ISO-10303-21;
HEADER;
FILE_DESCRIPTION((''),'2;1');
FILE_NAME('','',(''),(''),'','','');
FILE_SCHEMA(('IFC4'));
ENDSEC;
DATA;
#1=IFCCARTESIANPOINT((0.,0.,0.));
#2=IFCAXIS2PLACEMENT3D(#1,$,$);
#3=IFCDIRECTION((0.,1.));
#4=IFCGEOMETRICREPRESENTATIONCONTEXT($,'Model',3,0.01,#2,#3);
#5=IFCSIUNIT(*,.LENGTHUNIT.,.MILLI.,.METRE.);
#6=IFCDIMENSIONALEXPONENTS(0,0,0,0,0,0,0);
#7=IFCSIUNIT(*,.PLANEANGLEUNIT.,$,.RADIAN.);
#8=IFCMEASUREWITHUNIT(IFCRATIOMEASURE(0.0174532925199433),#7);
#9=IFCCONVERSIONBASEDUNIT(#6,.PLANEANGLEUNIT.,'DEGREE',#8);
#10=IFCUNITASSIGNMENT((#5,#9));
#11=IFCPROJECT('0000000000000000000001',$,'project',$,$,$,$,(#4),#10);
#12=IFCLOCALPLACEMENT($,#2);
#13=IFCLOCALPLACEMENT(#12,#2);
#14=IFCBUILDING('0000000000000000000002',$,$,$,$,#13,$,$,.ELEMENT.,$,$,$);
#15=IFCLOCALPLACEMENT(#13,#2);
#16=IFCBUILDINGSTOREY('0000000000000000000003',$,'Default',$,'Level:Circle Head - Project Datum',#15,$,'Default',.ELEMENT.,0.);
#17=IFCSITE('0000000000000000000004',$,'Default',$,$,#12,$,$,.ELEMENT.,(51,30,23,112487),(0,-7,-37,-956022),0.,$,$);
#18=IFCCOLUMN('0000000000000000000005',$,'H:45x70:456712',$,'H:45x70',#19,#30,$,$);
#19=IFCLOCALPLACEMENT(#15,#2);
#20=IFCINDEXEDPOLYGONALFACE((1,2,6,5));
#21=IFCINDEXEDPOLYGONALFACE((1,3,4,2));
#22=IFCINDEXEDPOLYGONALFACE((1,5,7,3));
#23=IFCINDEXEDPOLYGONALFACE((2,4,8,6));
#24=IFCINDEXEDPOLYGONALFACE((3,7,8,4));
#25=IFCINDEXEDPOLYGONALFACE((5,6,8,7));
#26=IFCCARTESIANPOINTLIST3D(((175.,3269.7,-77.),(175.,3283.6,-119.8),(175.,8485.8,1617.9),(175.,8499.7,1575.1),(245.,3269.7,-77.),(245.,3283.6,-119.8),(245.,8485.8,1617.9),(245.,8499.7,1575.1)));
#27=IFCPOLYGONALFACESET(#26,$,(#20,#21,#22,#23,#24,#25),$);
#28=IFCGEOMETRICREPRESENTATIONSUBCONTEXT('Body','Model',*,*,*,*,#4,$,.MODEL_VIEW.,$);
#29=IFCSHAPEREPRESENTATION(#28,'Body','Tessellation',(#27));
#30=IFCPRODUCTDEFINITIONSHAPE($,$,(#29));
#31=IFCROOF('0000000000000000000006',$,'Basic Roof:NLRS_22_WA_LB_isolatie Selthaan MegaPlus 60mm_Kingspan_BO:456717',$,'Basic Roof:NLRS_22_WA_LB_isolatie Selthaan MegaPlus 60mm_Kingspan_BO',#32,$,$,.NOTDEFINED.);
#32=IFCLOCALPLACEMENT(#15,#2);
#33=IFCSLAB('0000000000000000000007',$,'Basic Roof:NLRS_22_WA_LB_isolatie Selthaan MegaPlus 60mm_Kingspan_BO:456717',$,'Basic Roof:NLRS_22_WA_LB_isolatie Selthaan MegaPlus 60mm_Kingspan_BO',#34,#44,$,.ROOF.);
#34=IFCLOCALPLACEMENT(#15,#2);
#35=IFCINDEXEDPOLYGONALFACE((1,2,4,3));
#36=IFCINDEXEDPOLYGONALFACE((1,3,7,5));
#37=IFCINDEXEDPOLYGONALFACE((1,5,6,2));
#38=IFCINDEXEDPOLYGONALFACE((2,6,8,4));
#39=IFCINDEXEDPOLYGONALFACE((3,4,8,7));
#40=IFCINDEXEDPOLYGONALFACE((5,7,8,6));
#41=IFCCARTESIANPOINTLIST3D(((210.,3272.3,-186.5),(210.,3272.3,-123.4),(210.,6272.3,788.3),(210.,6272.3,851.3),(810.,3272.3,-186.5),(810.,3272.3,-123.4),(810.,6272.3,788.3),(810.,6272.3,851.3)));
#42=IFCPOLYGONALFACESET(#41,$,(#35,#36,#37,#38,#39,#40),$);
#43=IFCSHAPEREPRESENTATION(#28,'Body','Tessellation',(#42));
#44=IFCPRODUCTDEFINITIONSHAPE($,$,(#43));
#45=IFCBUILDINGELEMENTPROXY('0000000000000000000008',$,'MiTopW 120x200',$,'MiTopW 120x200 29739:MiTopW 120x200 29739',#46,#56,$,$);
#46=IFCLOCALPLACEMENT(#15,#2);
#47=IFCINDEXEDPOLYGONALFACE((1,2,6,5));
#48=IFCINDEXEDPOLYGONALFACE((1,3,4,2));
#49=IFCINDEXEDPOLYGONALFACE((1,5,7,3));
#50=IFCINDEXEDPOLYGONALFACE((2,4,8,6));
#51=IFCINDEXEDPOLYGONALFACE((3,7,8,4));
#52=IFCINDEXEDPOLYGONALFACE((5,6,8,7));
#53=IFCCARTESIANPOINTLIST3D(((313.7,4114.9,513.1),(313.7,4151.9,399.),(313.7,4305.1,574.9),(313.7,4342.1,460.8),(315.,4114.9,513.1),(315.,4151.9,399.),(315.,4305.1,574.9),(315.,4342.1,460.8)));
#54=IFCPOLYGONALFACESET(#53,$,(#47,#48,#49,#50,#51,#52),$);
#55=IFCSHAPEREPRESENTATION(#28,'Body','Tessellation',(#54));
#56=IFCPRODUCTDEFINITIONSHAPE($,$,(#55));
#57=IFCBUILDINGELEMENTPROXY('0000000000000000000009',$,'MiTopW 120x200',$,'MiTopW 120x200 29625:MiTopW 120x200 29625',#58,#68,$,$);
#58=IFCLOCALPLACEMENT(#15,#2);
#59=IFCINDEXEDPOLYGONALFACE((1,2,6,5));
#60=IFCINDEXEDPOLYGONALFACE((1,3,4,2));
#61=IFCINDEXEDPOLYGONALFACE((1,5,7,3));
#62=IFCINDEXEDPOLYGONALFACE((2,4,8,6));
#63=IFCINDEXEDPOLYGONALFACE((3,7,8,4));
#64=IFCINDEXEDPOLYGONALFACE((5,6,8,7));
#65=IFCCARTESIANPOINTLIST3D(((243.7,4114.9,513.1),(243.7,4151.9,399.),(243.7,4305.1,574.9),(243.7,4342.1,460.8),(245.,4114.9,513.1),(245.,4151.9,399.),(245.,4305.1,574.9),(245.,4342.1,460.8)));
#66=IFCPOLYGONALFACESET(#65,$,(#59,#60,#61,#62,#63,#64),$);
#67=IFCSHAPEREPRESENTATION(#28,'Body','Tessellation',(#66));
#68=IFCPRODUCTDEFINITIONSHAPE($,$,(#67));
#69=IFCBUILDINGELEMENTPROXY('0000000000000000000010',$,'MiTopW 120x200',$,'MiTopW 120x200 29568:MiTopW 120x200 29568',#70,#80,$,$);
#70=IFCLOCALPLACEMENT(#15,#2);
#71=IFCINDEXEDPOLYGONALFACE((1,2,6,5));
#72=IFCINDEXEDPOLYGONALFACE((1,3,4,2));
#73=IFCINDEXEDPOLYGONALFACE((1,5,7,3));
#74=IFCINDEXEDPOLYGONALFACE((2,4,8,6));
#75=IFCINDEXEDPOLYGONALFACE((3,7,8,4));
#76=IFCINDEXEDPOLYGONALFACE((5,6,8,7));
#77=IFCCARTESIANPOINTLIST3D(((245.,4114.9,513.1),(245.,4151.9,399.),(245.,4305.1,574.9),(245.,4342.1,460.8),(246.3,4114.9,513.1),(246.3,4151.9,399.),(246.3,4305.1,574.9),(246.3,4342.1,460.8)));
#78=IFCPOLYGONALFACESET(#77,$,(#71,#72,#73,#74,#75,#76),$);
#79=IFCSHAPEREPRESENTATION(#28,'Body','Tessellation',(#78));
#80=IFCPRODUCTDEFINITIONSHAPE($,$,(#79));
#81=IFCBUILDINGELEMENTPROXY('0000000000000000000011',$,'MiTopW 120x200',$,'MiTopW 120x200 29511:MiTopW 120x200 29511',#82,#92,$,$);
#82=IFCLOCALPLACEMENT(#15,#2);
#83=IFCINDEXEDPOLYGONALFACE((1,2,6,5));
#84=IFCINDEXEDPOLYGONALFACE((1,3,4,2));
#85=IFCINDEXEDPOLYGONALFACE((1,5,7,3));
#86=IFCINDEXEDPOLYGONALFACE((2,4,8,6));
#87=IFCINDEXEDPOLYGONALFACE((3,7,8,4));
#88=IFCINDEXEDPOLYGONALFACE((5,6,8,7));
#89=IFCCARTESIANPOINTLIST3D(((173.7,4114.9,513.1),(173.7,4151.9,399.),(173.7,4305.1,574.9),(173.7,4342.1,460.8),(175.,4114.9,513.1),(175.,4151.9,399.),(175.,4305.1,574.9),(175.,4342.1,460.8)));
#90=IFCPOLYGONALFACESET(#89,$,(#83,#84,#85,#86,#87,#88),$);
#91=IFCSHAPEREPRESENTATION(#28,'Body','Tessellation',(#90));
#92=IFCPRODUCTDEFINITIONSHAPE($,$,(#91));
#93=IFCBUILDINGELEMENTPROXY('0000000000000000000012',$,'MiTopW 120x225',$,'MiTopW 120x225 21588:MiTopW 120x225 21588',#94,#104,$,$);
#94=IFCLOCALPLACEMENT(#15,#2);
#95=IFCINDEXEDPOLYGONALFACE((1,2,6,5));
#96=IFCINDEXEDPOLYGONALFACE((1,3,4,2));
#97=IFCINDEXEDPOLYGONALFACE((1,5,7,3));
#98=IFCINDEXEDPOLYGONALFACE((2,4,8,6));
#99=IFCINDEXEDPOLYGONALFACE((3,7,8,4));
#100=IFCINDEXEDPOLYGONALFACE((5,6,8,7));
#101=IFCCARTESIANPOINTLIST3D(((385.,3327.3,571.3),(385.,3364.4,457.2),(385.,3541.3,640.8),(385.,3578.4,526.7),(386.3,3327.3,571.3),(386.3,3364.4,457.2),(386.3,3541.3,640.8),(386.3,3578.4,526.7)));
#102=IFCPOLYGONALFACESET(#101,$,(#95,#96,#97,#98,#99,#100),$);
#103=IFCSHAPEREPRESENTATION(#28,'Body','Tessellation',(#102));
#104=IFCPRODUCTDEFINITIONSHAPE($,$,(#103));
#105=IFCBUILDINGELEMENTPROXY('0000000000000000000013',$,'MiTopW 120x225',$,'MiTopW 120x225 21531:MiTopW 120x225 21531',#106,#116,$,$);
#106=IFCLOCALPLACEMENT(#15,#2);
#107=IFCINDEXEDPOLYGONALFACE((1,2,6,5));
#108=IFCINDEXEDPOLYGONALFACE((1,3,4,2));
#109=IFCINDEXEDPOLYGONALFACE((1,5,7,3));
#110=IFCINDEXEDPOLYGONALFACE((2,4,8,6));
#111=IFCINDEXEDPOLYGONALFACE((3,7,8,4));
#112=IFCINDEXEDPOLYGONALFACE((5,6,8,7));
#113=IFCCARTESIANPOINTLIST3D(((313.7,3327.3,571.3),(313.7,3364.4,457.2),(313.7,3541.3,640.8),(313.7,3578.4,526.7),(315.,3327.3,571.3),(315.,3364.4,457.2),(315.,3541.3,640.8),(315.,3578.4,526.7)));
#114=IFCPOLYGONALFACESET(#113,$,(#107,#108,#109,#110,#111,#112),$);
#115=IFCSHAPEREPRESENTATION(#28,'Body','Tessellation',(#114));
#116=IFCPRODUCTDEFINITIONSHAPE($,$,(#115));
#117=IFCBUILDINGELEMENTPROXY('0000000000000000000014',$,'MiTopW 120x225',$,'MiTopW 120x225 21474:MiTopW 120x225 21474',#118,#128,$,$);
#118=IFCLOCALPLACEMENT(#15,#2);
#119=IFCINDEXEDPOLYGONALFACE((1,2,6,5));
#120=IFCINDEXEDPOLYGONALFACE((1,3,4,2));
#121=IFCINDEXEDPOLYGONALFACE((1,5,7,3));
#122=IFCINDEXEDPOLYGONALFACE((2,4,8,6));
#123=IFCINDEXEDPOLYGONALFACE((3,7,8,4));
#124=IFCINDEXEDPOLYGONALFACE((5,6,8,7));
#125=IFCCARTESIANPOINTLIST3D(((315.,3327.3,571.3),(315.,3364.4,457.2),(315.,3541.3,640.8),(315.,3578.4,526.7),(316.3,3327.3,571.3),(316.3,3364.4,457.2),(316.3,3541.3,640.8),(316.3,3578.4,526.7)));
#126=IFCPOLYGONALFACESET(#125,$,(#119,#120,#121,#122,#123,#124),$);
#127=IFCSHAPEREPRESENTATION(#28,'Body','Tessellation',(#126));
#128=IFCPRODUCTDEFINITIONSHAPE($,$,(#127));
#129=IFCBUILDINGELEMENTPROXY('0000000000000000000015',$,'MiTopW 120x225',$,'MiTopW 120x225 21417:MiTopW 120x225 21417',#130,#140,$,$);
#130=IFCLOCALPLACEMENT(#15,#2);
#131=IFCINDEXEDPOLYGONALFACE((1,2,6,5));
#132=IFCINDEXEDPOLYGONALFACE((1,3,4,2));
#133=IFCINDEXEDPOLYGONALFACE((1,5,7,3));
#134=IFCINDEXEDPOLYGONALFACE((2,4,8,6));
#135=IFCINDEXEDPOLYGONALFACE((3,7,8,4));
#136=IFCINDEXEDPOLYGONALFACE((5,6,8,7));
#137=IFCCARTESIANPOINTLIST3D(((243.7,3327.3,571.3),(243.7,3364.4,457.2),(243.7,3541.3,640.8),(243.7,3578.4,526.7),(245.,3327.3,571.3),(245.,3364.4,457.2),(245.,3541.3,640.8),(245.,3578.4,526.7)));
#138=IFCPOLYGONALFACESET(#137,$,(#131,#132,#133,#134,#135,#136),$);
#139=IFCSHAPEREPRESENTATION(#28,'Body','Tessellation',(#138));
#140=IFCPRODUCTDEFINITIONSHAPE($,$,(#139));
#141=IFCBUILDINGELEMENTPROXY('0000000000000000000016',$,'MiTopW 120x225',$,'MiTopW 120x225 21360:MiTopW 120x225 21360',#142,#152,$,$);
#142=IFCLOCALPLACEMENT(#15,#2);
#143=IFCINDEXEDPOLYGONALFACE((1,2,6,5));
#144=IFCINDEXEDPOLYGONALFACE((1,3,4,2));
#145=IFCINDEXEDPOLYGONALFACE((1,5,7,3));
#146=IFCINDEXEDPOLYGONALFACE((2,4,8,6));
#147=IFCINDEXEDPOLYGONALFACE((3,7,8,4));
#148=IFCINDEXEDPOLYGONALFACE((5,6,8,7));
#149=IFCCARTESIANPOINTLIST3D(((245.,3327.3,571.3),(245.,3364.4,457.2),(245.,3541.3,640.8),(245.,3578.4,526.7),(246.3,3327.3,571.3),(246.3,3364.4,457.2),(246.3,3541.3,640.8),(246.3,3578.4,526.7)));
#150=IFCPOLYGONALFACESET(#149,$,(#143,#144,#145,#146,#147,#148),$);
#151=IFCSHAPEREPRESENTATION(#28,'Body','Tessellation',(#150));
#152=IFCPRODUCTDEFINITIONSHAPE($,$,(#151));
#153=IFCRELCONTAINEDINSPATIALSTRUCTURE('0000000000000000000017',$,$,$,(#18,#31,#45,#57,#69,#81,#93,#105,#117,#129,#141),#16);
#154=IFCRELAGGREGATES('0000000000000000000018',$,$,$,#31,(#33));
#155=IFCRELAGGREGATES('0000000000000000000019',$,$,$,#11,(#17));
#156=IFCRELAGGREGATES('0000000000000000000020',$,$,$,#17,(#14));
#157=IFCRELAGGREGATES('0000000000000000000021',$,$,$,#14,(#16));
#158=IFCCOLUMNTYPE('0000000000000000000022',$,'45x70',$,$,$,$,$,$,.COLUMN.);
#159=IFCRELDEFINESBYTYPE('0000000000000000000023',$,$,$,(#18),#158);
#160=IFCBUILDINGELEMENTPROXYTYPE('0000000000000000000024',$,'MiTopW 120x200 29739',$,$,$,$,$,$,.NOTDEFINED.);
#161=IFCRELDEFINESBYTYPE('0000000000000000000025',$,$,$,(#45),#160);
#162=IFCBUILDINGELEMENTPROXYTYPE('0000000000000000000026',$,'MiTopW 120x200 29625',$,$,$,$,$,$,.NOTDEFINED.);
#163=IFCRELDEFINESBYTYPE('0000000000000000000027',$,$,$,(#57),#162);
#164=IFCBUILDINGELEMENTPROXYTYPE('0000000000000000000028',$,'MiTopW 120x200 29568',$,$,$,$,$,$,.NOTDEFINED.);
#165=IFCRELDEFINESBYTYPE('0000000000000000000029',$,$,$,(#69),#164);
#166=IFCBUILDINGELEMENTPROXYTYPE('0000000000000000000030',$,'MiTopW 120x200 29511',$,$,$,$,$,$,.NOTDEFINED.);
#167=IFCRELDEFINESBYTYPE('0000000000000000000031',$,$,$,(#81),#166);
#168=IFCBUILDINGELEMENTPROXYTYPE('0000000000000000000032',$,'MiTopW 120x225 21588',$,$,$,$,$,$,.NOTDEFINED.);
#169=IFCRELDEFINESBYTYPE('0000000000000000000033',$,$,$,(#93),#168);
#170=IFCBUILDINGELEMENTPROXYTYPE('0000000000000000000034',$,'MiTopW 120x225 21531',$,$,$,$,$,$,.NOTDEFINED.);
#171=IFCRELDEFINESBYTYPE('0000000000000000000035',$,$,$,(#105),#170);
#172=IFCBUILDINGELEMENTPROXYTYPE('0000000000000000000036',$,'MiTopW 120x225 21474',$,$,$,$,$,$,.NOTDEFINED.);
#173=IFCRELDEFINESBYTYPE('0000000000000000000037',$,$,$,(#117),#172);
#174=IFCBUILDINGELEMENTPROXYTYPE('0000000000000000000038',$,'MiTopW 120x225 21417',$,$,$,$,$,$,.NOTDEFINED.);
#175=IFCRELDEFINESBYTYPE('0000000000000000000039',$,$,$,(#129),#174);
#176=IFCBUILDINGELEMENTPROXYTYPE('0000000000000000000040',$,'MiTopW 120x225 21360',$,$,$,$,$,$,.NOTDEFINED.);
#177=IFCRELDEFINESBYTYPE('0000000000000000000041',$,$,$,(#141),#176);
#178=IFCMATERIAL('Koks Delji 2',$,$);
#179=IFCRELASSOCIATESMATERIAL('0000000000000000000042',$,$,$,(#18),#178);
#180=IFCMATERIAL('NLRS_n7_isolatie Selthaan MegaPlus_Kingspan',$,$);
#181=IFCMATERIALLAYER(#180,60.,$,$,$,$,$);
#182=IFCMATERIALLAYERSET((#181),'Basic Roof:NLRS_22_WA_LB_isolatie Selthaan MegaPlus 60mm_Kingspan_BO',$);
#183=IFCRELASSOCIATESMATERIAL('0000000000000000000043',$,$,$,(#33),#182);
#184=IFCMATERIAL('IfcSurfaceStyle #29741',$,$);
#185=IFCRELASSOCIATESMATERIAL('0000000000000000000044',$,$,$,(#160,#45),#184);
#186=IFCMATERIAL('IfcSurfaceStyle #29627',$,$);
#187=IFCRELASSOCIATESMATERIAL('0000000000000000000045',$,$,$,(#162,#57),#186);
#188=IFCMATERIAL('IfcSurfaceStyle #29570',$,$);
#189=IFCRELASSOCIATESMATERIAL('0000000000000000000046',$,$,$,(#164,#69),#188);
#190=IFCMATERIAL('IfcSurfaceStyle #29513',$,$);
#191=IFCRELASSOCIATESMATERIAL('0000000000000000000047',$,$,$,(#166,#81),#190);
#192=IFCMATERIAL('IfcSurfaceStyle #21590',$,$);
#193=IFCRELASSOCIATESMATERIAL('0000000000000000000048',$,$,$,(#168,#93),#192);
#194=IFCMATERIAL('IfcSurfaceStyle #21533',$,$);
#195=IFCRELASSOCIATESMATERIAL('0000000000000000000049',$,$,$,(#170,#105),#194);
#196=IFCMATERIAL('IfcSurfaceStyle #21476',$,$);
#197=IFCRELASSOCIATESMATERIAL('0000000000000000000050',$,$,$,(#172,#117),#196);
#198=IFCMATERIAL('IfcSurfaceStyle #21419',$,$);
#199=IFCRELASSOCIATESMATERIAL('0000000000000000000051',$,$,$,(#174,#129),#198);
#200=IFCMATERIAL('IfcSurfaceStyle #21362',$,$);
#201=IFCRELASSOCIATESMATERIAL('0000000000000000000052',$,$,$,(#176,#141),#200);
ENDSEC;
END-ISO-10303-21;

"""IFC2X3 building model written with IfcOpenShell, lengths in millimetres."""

from ifc_helpers import new_model, entity, si_unit, converted_unit, direction, frame, frame_2d, origin, place, context, subcontext, project, spatial, polyline, rectangle, outline, extrude, source, transform, mapped, material, layer, layer_set, type_object, type_shapes, element, aggregate, save


model = new_model("IFC2X3")

# Units and contexts
model_context = context("Model", 3, precision=0.01, world=origin(), true_north=direction((0.0, 1.0)))
body_context = subcontext(model_context, "Body", "Model", "MODEL_VIEW")
ifc_project = project(units=[si_unit("LENGTHUNIT", "METRE", prefix="MILLI"), converted_unit("PLANEANGLEUNIT", "DEGREE", entity("IfcRatioMeasure", 0.0174532925199433), si_unit("PLANEANGLEUNIT", "RADIAN"), dimensions=[0, 0, 0, 0, 0, 0, 0])], contexts=[model_context])

# Site, building, storey
site_placement = place(None, origin())
site = spatial("IfcSite", under=ifc_project, at=site_placement, Name="Default", CompositionType="ELEMENT", RefLatitude=(51, 30, 23, 112487), RefLongitude=(0, -7, -37, -956022), RefElevation=0.0)
building_placement = place(site_placement, origin())
building = spatial("IfcBuilding", under=site, at=building_placement, CompositionType="ELEMENT")
storey_placement = place(building_placement, origin())
storey = spatial("IfcBuildingStorey", under=building, at=storey_placement, Name="Default", ObjectType="Level:Circle Head - Project Datum", LongName="Default", CompositionType="ELEMENT", Elevation=0.0)

# Column
ifc_material_1 = material(Name="Koks Delji 2")
column_type_1 = type_object("IfcColumnType", Name="45x70", PredefinedType="COLUMN")
shared_shape_1 = source(origin(), body_context, "Body", "SweptSolid", [
    extrude(rectangle(XDim=5484.5, YDim=70.0, at=frame_2d((0.0, 0.0), x_axis=(1.0, 0.0))), frame((2608.0, 237.8, 847.4), z_axis=(-0.309017, 0.0, 0.951057), x_axis=(-0.951057, 0.0, -0.309017)), (0.0, 0.0, 1.0), 45.0),
])
type_shapes(column_type_1, [shared_shape_1])
column_1_placement = place(storey_placement, frame((447.8, 3283.6, -119.8), z_axis=(0.0, 0.0, 1.0), x_axis=(0.0, 1.0, 0.0)))
element("IfcColumn", 1, at=column_1_placement, inside=storey, type_object=column_type_1, material=ifc_material_1, Name="H:45x70:456712", ObjectType="H:45x70", context=body_context, shape_type="MappedRepresentation", body=[
    mapped(shared_shape_1, transform((0.0, 0.0, 0.0), scale=1.0)),
])

# Roof, slab
roof_placement = place(storey_placement, frame((210.0, 3272.3, -186.5)))
roof = element("IfcRoof", 2, at=roof_placement, inside=storey, Name="Basic Roof:NLRS_22_WA_LB_isolatie Selthaan MegaPlus 60mm_Kingspan_BO:456717", ObjectType="Basic Roof:NLRS_22_WA_LB_isolatie Selthaan MegaPlus 60mm_Kingspan_BO", ShapeType="NOTDEFINED")
ifc_material_2 = material(Name="NLRS_n7_isolatie Selthaan MegaPlus_Kingspan")
ifc_layer = layer(ifc_material_2, 60.0)
ifc_layer_set = layer_set([ifc_layer], Name="Basic Roof:NLRS_22_WA_LB_isolatie Selthaan MegaPlus 60mm_Kingspan_BO")
slab_placement = place(roof_placement, origin())
slab = element("IfcSlab", 3, at=slab_placement, material=ifc_layer_set, Name="Basic Roof:NLRS_22_WA_LB_isolatie Selthaan MegaPlus 60mm_Kingspan_BO:456717", ObjectType="Basic Roof:NLRS_22_WA_LB_isolatie Selthaan MegaPlus 60mm_Kingspan_BO", PredefinedType="ROOF", context=body_context, shape_type="SweptSolid", body=[
    extrude(rectangle(XDim=600.0, YDim=3154.4, at=frame_2d((0.0, 0.0), x_axis=(-1.0, 0.0))), frame((300.0, 1500.0, 487.4), z_axis=(0.0, -0.309017, 0.951057), x_axis=(1.0, 0.0, 0.0)), (0.0, 0.309017, 0.951057), 63.1),
])
aggregate(roof, [slab])

# Building element proxies
ifc_material_3 = material(Name="IfcSurfaceStyle #29741")
building_element_proxy_type_1 = type_object("IfcBuildingElementProxyType", Name="MiTopW 120x200 29739", PredefinedType="NOTDEFINED", material=ifc_material_3)
shared_shape_2 = source(origin(), body_context, "Body", "SweptSolid", [
    extrude(outline(polyline([(-100.0, -60.0), (100.0, -60.0), (100.0, 60.0), (-100.0, 60.0), (-100.0, -60.0)])), frame((100.0, 60.0, 0.0), z_axis=(0.0, 0.0, 1.0), x_axis=(-1.0, 0.0, 0.0)), (0.0, 0.0, 1.0), 1.3),
])
type_shapes(building_element_proxy_type_1, [shared_shape_2])
proxy_1_placement = place(building_placement, frame((315.0, 4114.9, 513.1), z_axis=(-1.0, 0.0, 0.0), x_axis=(0.0, 0.951057, 0.309017)))
element("IfcBuildingElementProxy", 4, at=proxy_1_placement, inside=storey, type_object=building_element_proxy_type_1, material=ifc_material_3, Name="MiTopW 120x200", ObjectType="MiTopW 120x200 29739:MiTopW 120x200 29739", context=body_context, shape_type="MappedRepresentation", body=[
    mapped(shared_shape_2, transform((0.0, 0.0, 0.0), scale=1.0)),
])
ifc_material_4 = material(Name="IfcSurfaceStyle #29627")
building_element_proxy_type_2 = type_object("IfcBuildingElementProxyType", Name="MiTopW 120x200 29625", PredefinedType="NOTDEFINED", material=ifc_material_4)
shared_shape_3 = source(origin(), body_context, "Body", "SweptSolid", [
    extrude(outline(polyline([(-100.0, -60.0), (100.0, -60.0), (100.0, 60.0), (-100.0, 60.0), (-100.0, -60.0)])), frame((100.0, 60.0, 0.0), z_axis=(0.0, 0.0, 1.0), x_axis=(-1.0, 0.0, 0.0)), (0.0, 0.0, 1.0), 1.3),
])
type_shapes(building_element_proxy_type_2, [shared_shape_3])
proxy_2_placement = place(building_placement, frame((245.0, 4114.9, 513.1), z_axis=(-1.0, 0.0, 0.0), x_axis=(0.0, 0.951057, 0.309017)))
element("IfcBuildingElementProxy", 5, at=proxy_2_placement, inside=storey, type_object=building_element_proxy_type_2, material=ifc_material_4, Name="MiTopW 120x200", ObjectType="MiTopW 120x200 29625:MiTopW 120x200 29625", context=body_context, shape_type="MappedRepresentation", body=[
    mapped(shared_shape_3, transform((0.0, 0.0, 0.0), scale=1.0)),
])
ifc_material_5 = material(Name="IfcSurfaceStyle #29570")
building_element_proxy_type_3 = type_object("IfcBuildingElementProxyType", Name="MiTopW 120x200 29568", PredefinedType="NOTDEFINED", material=ifc_material_5)
shared_shape_4 = source(origin(), body_context, "Body", "SweptSolid", [
    extrude(outline(polyline([(-100.0, -60.0), (100.0, -60.0), (100.0, 60.0), (-100.0, 60.0), (-100.0, -60.0)])), frame((100.0, 60.0, 0.0), z_axis=(0.0, 0.0, 1.0), x_axis=(-1.0, 0.0, 0.0)), (0.0, 0.0, 1.0), 1.3),
])
type_shapes(building_element_proxy_type_3, [shared_shape_4])
proxy_3_placement = place(building_placement, frame((246.3, 4114.9, 513.1), z_axis=(-1.0, 0.0, 0.0), x_axis=(0.0, 0.951057, 0.309017)))
element("IfcBuildingElementProxy", 6, at=proxy_3_placement, inside=storey, type_object=building_element_proxy_type_3, material=ifc_material_5, Name="MiTopW 120x200", ObjectType="MiTopW 120x200 29568:MiTopW 120x200 29568", context=body_context, shape_type="MappedRepresentation", body=[
    mapped(shared_shape_4, transform((0.0, 0.0, 0.0), scale=1.0)),
])
ifc_material_6 = material(Name="IfcSurfaceStyle #29513")
building_element_proxy_type_4 = type_object("IfcBuildingElementProxyType", Name="MiTopW 120x200 29511", PredefinedType="NOTDEFINED", material=ifc_material_6)
shared_shape_5 = source(origin(), body_context, "Body", "SweptSolid", [
    extrude(outline(polyline([(-100.0, -60.0), (100.0, -60.0), (100.0, 60.0), (-100.0, 60.0), (-100.0, -60.0)])), frame((100.0, 60.0, 0.0), z_axis=(0.0, 0.0, 1.0), x_axis=(-1.0, 0.0, 0.0)), (0.0, 0.0, 1.0), 1.3),
])
type_shapes(building_element_proxy_type_4, [shared_shape_5])
proxy_4_placement = place(building_placement, frame((175.0, 4114.9, 513.1), z_axis=(-1.0, 0.0, 0.0), x_axis=(0.0, 0.951057, 0.309017)))
element("IfcBuildingElementProxy", 7, at=proxy_4_placement, inside=storey, type_object=building_element_proxy_type_4, material=ifc_material_6, Name="MiTopW 120x200", ObjectType="MiTopW 120x200 29511:MiTopW 120x200 29511", context=body_context, shape_type="MappedRepresentation", body=[
    mapped(shared_shape_5, transform((0.0, 0.0, 0.0), scale=1.0)),
])
ifc_material_7 = material(Name="IfcSurfaceStyle #21590")
building_element_proxy_type_5 = type_object("IfcBuildingElementProxyType", Name="MiTopW 120x225 21588", PredefinedType="NOTDEFINED", material=ifc_material_7)
shared_shape_6 = source(origin(), body_context, "Body", "SweptSolid", [
    extrude(outline(polyline([(-112.5, -60.0), (112.5, -60.0), (112.5, 60.0), (-112.5, 60.0), (-112.5, -60.0)])), frame((112.5, 60.0, 0.0), z_axis=(0.0, 0.0, 1.0), x_axis=(-1.0, 0.0, 0.0)), (0.0, 0.0, 1.0), 1.3),
])
type_shapes(building_element_proxy_type_5, [shared_shape_6])
proxy_5_placement = place(building_placement, frame((386.3, 3327.3, 571.3), z_axis=(-1.0, 0.0, 0.0), x_axis=(0.0, 0.951057, 0.309017)))
element("IfcBuildingElementProxy", 8, at=proxy_5_placement, inside=storey, type_object=building_element_proxy_type_5, material=ifc_material_7, Name="MiTopW 120x225", ObjectType="MiTopW 120x225 21588:MiTopW 120x225 21588", context=body_context, shape_type="MappedRepresentation", body=[
    mapped(shared_shape_6, transform((0.0, 0.0, 0.0), scale=1.0)),
])
ifc_material_8 = material(Name="IfcSurfaceStyle #21533")
building_element_proxy_type_6 = type_object("IfcBuildingElementProxyType", Name="MiTopW 120x225 21531", PredefinedType="NOTDEFINED", material=ifc_material_8)
shared_shape_7 = source(origin(), body_context, "Body", "SweptSolid", [
    extrude(outline(polyline([(-112.5, -60.0), (112.5, -60.0), (112.5, 60.0), (-112.5, 60.0), (-112.5, -60.0)])), frame((112.5, 60.0, 0.0), z_axis=(0.0, 0.0, 1.0), x_axis=(-1.0, 0.0, 0.0)), (0.0, 0.0, 1.0), 1.3),
])
type_shapes(building_element_proxy_type_6, [shared_shape_7])
proxy_6_placement = place(building_placement, frame((315.0, 3327.3, 571.3), z_axis=(-1.0, 0.0, 0.0), x_axis=(0.0, 0.951057, 0.309017)))
element("IfcBuildingElementProxy", 9, at=proxy_6_placement, inside=storey, type_object=building_element_proxy_type_6, material=ifc_material_8, Name="MiTopW 120x225", ObjectType="MiTopW 120x225 21531:MiTopW 120x225 21531", context=body_context, shape_type="MappedRepresentation", body=[
    mapped(shared_shape_7, transform((0.0, 0.0, 0.0), scale=1.0)),
])
ifc_material_9 = material(Name="IfcSurfaceStyle #21476")
building_element_proxy_type_7 = type_object("IfcBuildingElementProxyType", Name="MiTopW 120x225 21474", PredefinedType="NOTDEFINED", material=ifc_material_9)
shared_shape_8 = source(origin(), body_context, "Body", "SweptSolid", [
    extrude(outline(polyline([(-112.5, -60.0), (112.5, -60.0), (112.5, 60.0), (-112.5, 60.0), (-112.5, -60.0)])), frame((112.5, 60.0, 0.0), z_axis=(0.0, 0.0, 1.0), x_axis=(-1.0, 0.0, 0.0)), (0.0, 0.0, 1.0), 1.3),
])
type_shapes(building_element_proxy_type_7, [shared_shape_8])
proxy_7_placement = place(building_placement, frame((316.3, 3327.3, 571.3), z_axis=(-1.0, 0.0, 0.0), x_axis=(0.0, 0.951057, 0.309017)))
element("IfcBuildingElementProxy", 10, at=proxy_7_placement, inside=storey, type_object=building_element_proxy_type_7, material=ifc_material_9, Name="MiTopW 120x225", ObjectType="MiTopW 120x225 21474:MiTopW 120x225 21474", context=body_context, shape_type="MappedRepresentation", body=[
    mapped(shared_shape_8, transform((0.0, 0.0, 0.0), scale=1.0)),
])
ifc_material_10 = material(Name="IfcSurfaceStyle #21419")
building_element_proxy_type_8 = type_object("IfcBuildingElementProxyType", Name="MiTopW 120x225 21417", PredefinedType="NOTDEFINED", material=ifc_material_10)
shared_shape_9 = source(origin(), body_context, "Body", "SweptSolid", [
    extrude(outline(polyline([(-112.5, -60.0), (112.5, -60.0), (112.5, 60.0), (-112.5, 60.0), (-112.5, -60.0)])), frame((112.5, 60.0, 0.0), z_axis=(0.0, 0.0, 1.0), x_axis=(-1.0, 0.0, 0.0)), (0.0, 0.0, 1.0), 1.3),
])
type_shapes(building_element_proxy_type_8, [shared_shape_9])
proxy_8_placement = place(building_placement, frame((245.0, 3327.3, 571.3), z_axis=(-1.0, 0.0, 0.0), x_axis=(0.0, 0.951057, 0.309017)))
element("IfcBuildingElementProxy", 11, at=proxy_8_placement, inside=storey, type_object=building_element_proxy_type_8, material=ifc_material_10, Name="MiTopW 120x225", ObjectType="MiTopW 120x225 21417:MiTopW 120x225 21417", context=body_context, shape_type="MappedRepresentation", body=[
    mapped(shared_shape_9, transform((0.0, 0.0, 0.0), scale=1.0)),
])
ifc_material_11 = material(Name="IfcSurfaceStyle #21362")
building_element_proxy_type_9 = type_object("IfcBuildingElementProxyType", Name="MiTopW 120x225 21360", PredefinedType="NOTDEFINED", material=ifc_material_11)
shared_shape_10 = source(origin(), body_context, "Body", "SweptSolid", [
    extrude(outline(polyline([(-112.5, -60.0), (112.5, -60.0), (112.5, 60.0), (-112.5, 60.0), (-112.5, -60.0)])), frame((112.5, 60.0, 0.0), z_axis=(0.0, 0.0, 1.0), x_axis=(-1.0, 0.0, 0.0)), (0.0, 0.0, 1.0), 1.3),
])
type_shapes(building_element_proxy_type_9, [shared_shape_10])
proxy_9_placement = place(building_placement, frame((246.3, 3327.3, 571.3), z_axis=(-1.0, 0.0, 0.0), x_axis=(0.0, 0.951057, 0.309017)))
element("IfcBuildingElementProxy", 12, at=proxy_9_placement, inside=storey, type_object=building_element_proxy_type_9, material=ifc_material_11, Name="MiTopW 120x225", ObjectType="MiTopW 120x225 21360:MiTopW 120x225 21360", context=body_context, shape_type="MappedRepresentation", body=[
    mapped(shared_shape_10, transform((0.0, 0.0, 0.0), scale=1.0)),
])

save(model, "model.ifc")
